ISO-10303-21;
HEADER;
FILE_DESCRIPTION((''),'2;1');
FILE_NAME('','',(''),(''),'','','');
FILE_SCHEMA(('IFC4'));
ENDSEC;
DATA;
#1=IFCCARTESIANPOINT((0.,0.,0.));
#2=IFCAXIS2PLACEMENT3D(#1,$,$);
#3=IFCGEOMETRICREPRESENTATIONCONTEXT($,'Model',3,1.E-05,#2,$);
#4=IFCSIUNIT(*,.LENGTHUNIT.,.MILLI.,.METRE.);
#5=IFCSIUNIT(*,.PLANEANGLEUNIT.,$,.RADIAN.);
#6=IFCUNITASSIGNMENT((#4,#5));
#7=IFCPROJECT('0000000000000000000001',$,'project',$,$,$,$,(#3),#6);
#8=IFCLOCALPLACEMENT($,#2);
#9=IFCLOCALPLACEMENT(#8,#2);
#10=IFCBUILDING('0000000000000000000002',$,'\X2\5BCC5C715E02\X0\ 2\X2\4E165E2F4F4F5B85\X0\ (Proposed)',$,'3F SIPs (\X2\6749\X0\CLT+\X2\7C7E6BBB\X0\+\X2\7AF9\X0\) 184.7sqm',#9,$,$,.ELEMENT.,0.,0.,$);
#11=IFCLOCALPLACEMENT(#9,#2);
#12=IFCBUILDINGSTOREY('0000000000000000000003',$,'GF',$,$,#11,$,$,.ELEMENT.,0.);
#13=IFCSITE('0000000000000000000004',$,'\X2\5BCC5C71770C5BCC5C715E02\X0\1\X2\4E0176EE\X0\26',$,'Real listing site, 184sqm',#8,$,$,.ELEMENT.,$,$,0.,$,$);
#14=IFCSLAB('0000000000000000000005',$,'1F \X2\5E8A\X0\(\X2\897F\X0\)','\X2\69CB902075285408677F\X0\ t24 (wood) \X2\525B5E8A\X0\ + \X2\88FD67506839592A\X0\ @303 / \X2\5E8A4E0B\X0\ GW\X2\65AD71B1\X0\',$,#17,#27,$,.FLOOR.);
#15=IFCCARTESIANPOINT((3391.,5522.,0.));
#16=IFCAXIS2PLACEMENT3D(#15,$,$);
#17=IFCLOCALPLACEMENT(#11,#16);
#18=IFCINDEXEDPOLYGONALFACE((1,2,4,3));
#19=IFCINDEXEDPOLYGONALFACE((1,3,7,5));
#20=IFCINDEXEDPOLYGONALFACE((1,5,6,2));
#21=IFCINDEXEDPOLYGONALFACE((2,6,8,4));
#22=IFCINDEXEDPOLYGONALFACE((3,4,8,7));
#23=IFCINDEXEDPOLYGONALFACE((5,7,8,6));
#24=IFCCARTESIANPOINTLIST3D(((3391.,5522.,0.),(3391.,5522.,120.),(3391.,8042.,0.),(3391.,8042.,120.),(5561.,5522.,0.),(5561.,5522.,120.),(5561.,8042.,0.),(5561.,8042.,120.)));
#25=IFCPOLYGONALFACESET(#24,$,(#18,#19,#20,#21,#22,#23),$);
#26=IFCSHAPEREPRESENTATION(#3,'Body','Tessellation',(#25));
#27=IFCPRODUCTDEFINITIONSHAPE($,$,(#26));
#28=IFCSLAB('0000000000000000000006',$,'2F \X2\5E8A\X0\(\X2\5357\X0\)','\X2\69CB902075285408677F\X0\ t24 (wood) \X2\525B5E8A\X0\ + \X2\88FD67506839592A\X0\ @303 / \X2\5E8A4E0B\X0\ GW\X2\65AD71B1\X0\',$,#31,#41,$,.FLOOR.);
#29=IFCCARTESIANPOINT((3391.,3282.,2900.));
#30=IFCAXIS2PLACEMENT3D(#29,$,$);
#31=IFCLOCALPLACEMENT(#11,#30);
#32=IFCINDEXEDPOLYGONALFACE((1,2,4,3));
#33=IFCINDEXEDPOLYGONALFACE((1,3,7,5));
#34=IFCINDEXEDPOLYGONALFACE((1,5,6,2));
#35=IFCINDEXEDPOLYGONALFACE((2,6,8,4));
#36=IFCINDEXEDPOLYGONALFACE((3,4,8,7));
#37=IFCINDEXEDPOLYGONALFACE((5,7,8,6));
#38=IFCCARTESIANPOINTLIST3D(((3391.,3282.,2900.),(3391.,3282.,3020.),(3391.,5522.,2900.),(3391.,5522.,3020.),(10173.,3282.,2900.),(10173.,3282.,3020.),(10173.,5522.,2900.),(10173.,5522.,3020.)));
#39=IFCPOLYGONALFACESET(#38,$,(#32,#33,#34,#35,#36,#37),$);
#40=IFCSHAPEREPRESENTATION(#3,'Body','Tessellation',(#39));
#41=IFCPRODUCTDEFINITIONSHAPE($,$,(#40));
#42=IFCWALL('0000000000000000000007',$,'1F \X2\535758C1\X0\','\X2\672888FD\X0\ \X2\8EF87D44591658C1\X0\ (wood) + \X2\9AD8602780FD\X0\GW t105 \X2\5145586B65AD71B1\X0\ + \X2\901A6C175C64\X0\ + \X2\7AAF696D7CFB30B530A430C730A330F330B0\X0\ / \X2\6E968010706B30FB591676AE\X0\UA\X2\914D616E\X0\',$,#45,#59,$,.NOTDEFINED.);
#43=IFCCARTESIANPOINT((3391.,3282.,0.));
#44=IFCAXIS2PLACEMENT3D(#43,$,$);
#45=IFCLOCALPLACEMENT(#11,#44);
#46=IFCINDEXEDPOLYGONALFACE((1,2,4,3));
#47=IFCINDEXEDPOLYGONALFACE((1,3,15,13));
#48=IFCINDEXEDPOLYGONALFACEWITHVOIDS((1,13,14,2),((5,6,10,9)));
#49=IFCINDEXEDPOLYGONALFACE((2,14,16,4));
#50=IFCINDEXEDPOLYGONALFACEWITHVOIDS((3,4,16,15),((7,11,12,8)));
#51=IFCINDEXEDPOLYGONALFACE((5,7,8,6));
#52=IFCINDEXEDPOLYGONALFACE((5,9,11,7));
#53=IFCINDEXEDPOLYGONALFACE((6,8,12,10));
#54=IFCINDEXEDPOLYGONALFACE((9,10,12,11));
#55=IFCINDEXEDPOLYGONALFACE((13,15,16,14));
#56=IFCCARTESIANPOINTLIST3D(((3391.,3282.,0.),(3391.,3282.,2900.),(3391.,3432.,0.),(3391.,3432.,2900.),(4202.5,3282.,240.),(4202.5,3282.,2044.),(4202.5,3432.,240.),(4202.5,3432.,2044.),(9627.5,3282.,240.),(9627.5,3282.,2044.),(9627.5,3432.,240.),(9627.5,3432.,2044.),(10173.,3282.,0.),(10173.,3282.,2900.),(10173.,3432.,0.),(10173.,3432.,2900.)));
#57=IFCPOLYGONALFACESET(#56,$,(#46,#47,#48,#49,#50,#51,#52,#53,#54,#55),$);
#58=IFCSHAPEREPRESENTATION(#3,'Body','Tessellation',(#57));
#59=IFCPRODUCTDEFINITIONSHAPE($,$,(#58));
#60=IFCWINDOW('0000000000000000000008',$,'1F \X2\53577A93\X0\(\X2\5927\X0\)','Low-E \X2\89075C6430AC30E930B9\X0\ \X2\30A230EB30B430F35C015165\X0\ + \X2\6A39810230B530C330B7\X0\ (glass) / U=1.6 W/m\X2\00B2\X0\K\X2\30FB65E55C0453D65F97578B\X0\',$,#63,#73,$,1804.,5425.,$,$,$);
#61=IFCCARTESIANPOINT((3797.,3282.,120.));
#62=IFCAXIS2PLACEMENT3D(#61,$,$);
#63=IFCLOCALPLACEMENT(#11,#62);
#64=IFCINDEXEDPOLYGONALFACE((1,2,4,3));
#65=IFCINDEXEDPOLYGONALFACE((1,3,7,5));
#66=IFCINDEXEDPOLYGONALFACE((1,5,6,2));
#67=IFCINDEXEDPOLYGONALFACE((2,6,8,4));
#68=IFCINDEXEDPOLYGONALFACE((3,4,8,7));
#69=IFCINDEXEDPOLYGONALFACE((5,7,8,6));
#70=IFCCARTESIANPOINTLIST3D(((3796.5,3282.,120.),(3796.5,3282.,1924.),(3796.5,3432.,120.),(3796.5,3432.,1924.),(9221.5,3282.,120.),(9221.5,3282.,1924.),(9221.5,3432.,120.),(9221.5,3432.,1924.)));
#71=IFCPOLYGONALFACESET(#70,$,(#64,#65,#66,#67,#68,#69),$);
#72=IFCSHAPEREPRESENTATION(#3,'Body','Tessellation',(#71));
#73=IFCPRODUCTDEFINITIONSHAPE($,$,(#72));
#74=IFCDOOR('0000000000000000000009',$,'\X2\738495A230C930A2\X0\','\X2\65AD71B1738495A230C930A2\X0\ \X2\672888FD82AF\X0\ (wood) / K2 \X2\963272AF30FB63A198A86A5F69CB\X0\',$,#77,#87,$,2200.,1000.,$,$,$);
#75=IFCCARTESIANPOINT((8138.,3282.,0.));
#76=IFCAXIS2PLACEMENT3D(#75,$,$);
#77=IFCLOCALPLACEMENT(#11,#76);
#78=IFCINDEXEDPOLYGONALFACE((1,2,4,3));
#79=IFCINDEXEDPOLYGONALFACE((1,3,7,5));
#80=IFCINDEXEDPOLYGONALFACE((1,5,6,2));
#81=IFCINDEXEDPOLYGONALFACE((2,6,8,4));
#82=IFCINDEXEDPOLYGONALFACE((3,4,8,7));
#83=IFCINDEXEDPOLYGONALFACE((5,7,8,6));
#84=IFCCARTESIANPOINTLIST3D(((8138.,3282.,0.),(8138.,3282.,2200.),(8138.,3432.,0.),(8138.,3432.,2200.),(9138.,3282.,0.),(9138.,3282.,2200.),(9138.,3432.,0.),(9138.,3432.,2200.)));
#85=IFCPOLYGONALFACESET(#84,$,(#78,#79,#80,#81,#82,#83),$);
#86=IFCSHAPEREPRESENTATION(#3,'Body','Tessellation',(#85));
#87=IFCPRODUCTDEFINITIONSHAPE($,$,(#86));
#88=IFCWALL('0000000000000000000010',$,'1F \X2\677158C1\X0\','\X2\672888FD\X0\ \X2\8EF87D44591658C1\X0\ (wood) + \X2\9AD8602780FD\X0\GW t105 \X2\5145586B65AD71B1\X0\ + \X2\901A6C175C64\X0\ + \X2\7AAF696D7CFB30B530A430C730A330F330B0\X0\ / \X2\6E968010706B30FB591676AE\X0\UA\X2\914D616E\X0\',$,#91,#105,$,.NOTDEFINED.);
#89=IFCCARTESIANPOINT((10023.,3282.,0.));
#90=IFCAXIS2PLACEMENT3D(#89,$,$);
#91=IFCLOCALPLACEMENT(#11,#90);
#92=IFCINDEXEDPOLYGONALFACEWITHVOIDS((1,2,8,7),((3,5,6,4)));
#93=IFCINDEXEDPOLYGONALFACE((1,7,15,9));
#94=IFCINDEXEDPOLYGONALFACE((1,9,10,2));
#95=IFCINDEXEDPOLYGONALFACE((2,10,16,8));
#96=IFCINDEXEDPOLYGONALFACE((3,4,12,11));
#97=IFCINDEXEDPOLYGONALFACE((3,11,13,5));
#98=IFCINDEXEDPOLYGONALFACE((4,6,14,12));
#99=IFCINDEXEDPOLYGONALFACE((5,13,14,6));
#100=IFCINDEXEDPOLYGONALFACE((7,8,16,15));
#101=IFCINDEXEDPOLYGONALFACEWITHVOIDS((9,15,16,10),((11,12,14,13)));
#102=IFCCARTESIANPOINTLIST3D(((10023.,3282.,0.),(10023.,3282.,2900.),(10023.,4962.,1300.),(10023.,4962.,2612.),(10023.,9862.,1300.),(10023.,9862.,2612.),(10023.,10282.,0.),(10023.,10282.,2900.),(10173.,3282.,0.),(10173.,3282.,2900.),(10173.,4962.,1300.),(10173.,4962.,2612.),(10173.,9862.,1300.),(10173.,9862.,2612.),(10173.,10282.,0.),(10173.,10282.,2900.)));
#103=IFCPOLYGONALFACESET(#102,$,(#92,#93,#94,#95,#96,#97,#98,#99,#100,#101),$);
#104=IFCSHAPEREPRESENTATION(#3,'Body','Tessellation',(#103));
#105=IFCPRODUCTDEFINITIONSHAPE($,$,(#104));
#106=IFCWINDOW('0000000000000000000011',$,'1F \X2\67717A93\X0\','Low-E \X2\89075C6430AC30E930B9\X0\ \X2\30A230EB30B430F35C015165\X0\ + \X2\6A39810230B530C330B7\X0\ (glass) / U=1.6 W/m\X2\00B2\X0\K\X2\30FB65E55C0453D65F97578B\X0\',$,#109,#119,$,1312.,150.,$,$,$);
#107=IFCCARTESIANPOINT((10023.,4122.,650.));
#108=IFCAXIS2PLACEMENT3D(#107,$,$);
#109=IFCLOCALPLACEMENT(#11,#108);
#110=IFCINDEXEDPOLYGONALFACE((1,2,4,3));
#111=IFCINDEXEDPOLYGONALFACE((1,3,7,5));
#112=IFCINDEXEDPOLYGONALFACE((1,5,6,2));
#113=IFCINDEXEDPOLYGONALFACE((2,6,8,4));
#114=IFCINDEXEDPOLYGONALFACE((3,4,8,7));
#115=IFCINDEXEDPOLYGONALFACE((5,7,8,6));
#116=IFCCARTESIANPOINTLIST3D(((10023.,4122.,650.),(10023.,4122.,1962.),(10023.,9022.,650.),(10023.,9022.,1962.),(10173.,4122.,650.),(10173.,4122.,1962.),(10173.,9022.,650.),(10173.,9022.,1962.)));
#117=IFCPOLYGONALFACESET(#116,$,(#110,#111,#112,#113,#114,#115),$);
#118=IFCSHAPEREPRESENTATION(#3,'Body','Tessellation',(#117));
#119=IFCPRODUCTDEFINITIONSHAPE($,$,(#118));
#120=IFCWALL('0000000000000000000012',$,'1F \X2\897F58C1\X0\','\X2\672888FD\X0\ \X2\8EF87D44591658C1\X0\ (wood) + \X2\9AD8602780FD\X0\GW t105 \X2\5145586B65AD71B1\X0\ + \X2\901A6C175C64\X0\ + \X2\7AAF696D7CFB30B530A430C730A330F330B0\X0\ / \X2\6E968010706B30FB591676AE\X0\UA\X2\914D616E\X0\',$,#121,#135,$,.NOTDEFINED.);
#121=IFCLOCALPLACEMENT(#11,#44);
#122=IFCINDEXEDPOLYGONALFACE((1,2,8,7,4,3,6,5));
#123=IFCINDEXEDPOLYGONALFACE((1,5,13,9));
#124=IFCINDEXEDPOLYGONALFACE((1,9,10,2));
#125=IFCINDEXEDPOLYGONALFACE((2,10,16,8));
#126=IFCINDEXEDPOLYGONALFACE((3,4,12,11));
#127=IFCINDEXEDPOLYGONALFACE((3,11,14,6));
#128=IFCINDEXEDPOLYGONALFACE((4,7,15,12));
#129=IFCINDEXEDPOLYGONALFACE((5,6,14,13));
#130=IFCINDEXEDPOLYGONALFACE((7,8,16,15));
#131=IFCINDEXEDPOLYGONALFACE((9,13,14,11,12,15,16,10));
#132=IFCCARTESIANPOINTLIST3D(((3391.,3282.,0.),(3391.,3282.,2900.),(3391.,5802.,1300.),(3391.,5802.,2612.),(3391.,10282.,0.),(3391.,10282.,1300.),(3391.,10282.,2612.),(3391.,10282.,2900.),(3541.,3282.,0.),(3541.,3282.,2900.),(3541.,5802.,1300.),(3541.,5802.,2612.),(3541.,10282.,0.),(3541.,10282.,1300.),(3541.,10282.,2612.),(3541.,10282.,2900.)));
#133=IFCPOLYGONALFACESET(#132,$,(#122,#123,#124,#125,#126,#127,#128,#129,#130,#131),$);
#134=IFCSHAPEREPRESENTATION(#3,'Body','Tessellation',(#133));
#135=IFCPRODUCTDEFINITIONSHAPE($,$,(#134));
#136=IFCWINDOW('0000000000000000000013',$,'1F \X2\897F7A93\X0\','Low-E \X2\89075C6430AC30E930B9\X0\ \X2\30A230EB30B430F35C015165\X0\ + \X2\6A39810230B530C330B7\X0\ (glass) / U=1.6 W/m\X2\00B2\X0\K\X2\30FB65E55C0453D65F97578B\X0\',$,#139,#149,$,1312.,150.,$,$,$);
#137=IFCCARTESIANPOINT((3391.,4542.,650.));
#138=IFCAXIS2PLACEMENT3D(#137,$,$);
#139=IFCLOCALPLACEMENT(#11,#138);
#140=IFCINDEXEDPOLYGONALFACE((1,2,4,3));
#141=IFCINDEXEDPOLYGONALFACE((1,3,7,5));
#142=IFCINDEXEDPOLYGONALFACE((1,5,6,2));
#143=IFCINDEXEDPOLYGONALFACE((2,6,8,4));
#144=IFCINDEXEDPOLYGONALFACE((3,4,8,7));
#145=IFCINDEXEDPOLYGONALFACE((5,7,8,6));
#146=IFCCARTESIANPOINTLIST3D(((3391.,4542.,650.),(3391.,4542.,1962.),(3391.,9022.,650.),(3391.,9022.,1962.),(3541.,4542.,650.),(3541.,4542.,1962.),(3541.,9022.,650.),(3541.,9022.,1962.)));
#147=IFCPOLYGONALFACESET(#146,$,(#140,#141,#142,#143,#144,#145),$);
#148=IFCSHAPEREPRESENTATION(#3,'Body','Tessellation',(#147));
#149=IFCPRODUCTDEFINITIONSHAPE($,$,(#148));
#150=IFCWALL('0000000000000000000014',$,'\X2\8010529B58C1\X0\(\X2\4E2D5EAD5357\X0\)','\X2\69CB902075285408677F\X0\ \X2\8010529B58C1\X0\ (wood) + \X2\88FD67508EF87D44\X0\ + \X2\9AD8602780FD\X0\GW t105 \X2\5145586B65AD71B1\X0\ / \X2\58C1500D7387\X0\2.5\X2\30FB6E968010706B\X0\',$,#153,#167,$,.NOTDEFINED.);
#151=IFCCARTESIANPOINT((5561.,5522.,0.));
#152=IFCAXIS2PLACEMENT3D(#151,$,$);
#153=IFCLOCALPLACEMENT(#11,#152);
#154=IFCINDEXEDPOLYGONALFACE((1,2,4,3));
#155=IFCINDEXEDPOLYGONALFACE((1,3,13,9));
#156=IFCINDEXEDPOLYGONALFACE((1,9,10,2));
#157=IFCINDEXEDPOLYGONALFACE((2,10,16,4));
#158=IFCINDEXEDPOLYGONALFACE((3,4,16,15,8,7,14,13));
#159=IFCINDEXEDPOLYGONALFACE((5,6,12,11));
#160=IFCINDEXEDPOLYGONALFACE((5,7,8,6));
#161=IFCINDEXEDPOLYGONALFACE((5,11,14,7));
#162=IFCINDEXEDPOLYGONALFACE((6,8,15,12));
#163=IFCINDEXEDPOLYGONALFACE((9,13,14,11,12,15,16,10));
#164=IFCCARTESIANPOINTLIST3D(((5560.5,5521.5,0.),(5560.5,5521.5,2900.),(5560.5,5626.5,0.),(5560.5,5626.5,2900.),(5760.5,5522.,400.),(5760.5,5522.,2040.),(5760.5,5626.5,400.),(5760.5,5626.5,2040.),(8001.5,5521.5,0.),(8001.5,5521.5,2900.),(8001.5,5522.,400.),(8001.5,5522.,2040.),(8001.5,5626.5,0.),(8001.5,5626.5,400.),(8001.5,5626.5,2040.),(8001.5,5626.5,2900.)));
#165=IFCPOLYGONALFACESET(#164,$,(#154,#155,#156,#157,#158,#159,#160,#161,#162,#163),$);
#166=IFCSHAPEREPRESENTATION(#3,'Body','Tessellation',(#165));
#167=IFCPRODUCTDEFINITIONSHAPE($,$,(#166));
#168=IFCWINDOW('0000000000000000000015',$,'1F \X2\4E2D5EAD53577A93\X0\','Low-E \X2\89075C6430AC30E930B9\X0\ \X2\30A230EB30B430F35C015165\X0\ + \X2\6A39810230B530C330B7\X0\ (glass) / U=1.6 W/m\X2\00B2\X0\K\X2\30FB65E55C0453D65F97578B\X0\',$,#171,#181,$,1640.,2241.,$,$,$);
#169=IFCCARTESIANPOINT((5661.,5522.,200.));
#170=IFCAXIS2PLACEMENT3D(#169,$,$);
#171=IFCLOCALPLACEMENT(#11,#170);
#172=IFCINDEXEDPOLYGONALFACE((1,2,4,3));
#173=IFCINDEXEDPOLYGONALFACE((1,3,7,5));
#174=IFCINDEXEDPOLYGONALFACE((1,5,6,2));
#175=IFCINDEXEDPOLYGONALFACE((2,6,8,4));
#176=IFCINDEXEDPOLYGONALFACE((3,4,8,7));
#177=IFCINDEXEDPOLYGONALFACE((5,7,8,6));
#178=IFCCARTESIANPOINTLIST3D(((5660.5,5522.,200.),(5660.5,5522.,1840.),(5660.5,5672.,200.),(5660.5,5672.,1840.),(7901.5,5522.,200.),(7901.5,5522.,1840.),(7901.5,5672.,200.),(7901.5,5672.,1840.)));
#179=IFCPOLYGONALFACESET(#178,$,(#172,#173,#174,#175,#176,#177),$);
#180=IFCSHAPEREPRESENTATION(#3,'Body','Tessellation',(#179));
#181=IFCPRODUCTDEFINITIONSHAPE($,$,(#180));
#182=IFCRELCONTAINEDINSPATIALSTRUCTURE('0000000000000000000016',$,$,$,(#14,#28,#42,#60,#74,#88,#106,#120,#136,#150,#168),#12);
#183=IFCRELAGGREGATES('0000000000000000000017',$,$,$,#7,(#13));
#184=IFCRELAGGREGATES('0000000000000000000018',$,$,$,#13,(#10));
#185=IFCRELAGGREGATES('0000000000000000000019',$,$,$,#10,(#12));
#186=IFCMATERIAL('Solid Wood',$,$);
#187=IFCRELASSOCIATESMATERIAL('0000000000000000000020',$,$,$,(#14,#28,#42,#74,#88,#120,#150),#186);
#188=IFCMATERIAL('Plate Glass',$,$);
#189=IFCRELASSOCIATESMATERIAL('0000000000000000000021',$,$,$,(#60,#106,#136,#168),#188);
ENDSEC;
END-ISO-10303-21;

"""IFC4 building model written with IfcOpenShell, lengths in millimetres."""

from ifc_helpers import new_model, si_unit, frame, frame_2d, origin, place, context, project, spatial, rectangle, extrude, material, element, fill, save


model = new_model("IFC4")

# Units and contexts
model_context = context("Model", 3, precision=1e-05, world=origin())
ifc_project = project(units=[si_unit("LENGTHUNIT", "METRE", prefix="MILLI"), si_unit("PLANEANGLEUNIT", "RADIAN")], contexts=[model_context])

# Site, building, storey
site_placement = place(None, origin())
site = spatial("IfcSite", under=ifc_project, at=site_placement, Name="富山県富山市1丁目26", ObjectType="Real listing site, 184sqm", CompositionType="ELEMENT", RefElevation=0.0)
building_placement = place(site_placement, origin())
building = spatial("IfcBuilding", under=site, at=building_placement, Name="富山市 2世帯住宅 (Proposed)", ObjectType="3F SIPs (杉CLT+籾殻+竹) 184.7sqm", CompositionType="ELEMENT", ElevationOfRefHeight=0.0, ElevationOfTerrain=0.0)
storey_placement = place(building_placement, origin())
storey = spatial("IfcBuildingStorey", under=building, at=storey_placement, Name="GF", CompositionType="ELEMENT", Elevation=0.0)

# Slabs
ifc_material_1 = material(Name="Solid Wood")
slab_1_placement = place(storey_placement, frame((3391.0, 5522.0, 0.0)))
element("IfcSlab", 1, at=slab_1_placement, inside=storey, material=ifc_material_1, Name="1F 床(西)", Description="構造用合板 t24 (wood) 剛床 + 製材根太 @303 / 床下 GW断熱", PredefinedType="FLOOR", context=model_context, shape_type="SweptSolid", body=[
    extrude(rectangle(XDim=2170.0, YDim=2520.0, at=frame_2d((1085.0, 1260.0))), frame((3391.0, 5522.0, 0.0)), (0.0, 0.0, 1.0), 120.0),
])
slab_2_placement = place(storey_placement, frame((3391.0, 3282.0, 2900.0)))
element("IfcSlab", 2, at=slab_2_placement, inside=storey, material=ifc_material_1, Name="2F 床(南)", Description="構造用合板 t24 (wood) 剛床 + 製材根太 @303 / 床下 GW断熱", PredefinedType="FLOOR", context=model_context, shape_type="SweptSolid", body=[
    extrude(rectangle(XDim=6782.0, YDim=2240.0, at=frame_2d((3391.0, 1120.0))), frame((3391.0, 3282.0, 2900.0)), (0.0, 0.0, 1.0), 120.0),
])

# Wall, openings, window, door
wall_1_placement = place(storey_placement, frame((3391.0, 3282.0, 0.0)))
wall_1 = element("IfcWall", 3, at=wall_1_placement, inside=storey, material=ifc_material_1, Name="1F 南壁", Description="木製 軸組外壁 (wood) + 高性能GW t105 充填断熱 + 通気層 + 窯業系サイディング / 準耐火・外皮UA配慮", PredefinedType="NOTDEFINED", context=model_context, shape_type="SweptSolid", body=[
    extrude(rectangle(XDim=6782.0, YDim=150.0, at=frame_2d((3391.0, 75.0))), frame((3391.0, 3282.0, 0.0)), (0.0, 0.0, 1.0), 2900.0),
])
opening_1_placement = place(storey_placement, frame((3797.0, 3282.0, 120.0)))
opening_1 = element("IfcOpeningElement", 4, at=opening_1_placement, cuts=wall_1, PredefinedType="NOTDEFINED", context=model_context, shape_type="SweptSolid", body=[
    extrude(rectangle(XDim=5425.0, YDim=150.0, at=frame_2d((2712.0, 75.0))), frame((3797.0, 3282.0, 120.0)), (0.0, 0.0, 1.0), 1804.0),
])
opening_2_placement = place(storey_placement, frame((8138.0, 3282.0, 0.0)))
opening_2 = element("IfcOpeningElement", 5, at=opening_2_placement, cuts=wall_1, PredefinedType="NOTDEFINED", context=model_context, shape_type="SweptSolid", body=[
    extrude(rectangle(XDim=1000.0, YDim=150.0, at=frame_2d((500.0, 75.0))), frame((8138.0, 3282.0, 0.0)), (0.0, 0.0, 1.0), 2200.0),
])
ifc_material_2 = material(Name="Plate Glass")
window_1_placement = place(storey_placement, frame((3797.0, 3282.0, 120.0)))
window_1 = element("IfcWindow", 6, at=window_1_placement, inside=storey, material=ifc_material_2, Name="1F 南窓(大)", Description="Low-E 複層ガラス アルゴン封入 + 樹脂サッシ (glass) / U=1.6 W/m²K・日射取得型", OverallHeight=1804.0, OverallWidth=5425.0, context=model_context, shape_type="SweptSolid", body=[
    extrude(rectangle(XDim=5425.0, YDim=150.0, at=frame_2d((2712.0, 75.0))), frame((3797.0, 3282.0, 120.0)), (0.0, 0.0, 1.0), 1804.0),
])
fill(opening_1, window_1)
door_placement = place(storey_placement, frame((8138.0, 3282.0, 0.0)))
door = element("IfcDoor", 7, at=door_placement, inside=storey, material=ifc_material_1, Name="玄関ドア", Description="断熱玄関ドア 木製芯 (wood) / K2 防犯・採風機構", OverallHeight=2200.0, OverallWidth=1000.0, context=model_context, shape_type="SweptSolid", body=[
    extrude(rectangle(XDim=1000.0, YDim=150.0, at=frame_2d((500.0, 75.0))), frame((8138.0, 3282.0, 0.0)), (0.0, 0.0, 1.0), 2200.0),
])
fill(opening_2, door)

# Walls, openings, windows
wall_2_placement = place(storey_placement, frame((10023.0, 3282.0, 0.0)))
wall_2 = element("IfcWall", 8, at=wall_2_placement, inside=storey, material=ifc_material_1, Name="1F 東壁", Description="木製 軸組外壁 (wood) + 高性能GW t105 充填断熱 + 通気層 + 窯業系サイディング / 準耐火・外皮UA配慮", PredefinedType="NOTDEFINED", context=model_context, shape_type="SweptSolid", body=[
    extrude(rectangle(XDim=150.0, YDim=7000.0, at=frame_2d((75.0, 3500.0))), frame((10023.0, 3282.0, 0.0)), (0.0, 0.0, 1.0), 2900.0),
])
opening_3_placement = place(storey_placement, frame((10023.0, 4122.0, 650.0)))
opening_3 = element("IfcOpeningElement", 9, at=opening_3_placement, cuts=wall_2, PredefinedType="NOTDEFINED", context=model_context, shape_type="SweptSolid", body=[
    extrude(rectangle(XDim=150.0, YDim=4900.0, at=frame_2d((75.0, 2450.0))), frame((10023.0, 4122.0, 650.0)), (0.0, 0.0, 1.0), 1312.0),
])
window_2_placement = place(storey_placement, frame((10023.0, 4122.0, 650.0)))
window_2 = element("IfcWindow", 10, at=window_2_placement, inside=storey, material=ifc_material_2, Name="1F 東窓", Description="Low-E 複層ガラス アルゴン封入 + 樹脂サッシ (glass) / U=1.6 W/m²K・日射取得型", OverallHeight=1312.0, OverallWidth=150.0, context=model_context, shape_type="SweptSolid", body=[
    extrude(rectangle(XDim=150.0, YDim=4900.0, at=frame_2d((75.0, 2450.0))), frame((10023.0, 4122.0, 650.0)), (0.0, 0.0, 1.0), 1312.0),
])
fill(opening_3, window_2)
wall_3_placement = place(storey_placement, frame((3391.0, 3282.0, 0.0)))
wall_3 = element("IfcWall", 11, at=wall_3_placement, inside=storey, material=ifc_material_1, Name="1F 西壁", Description="木製 軸組外壁 (wood) + 高性能GW t105 充填断熱 + 通気層 + 窯業系サイディング / 準耐火・外皮UA配慮", PredefinedType="NOTDEFINED", context=model_context, shape_type="SweptSolid", body=[
    extrude(rectangle(XDim=150.0, YDim=7000.0, at=frame_2d((75.0, 3500.0))), frame((3391.0, 3282.0, 0.0)), (0.0, 0.0, 1.0), 2900.0),
])
opening_4_placement = place(storey_placement, frame((3391.0, 4542.0, 650.0)))
opening_4 = element("IfcOpeningElement", 12, at=opening_4_placement, cuts=wall_3, PredefinedType="NOTDEFINED", context=model_context, shape_type="SweptSolid", body=[
    extrude(rectangle(XDim=150.0, YDim=4480.0, at=frame_2d((75.0, 2240.0))), frame((3391.0, 4542.0, 650.0)), (0.0, 0.0, 1.0), 1312.0),
])
window_3_placement = place(storey_placement, frame((3391.0, 4542.0, 650.0)))
window_3 = element("IfcWindow", 13, at=window_3_placement, inside=storey, material=ifc_material_2, Name="1F 西窓", Description="Low-E 複層ガラス アルゴン封入 + 樹脂サッシ (glass) / U=1.6 W/m²K・日射取得型", OverallHeight=1312.0, OverallWidth=150.0, context=model_context, shape_type="SweptSolid", body=[
    extrude(rectangle(XDim=150.0, YDim=4480.0, at=frame_2d((75.0, 2240.0))), frame((3391.0, 4542.0, 650.0)), (0.0, 0.0, 1.0), 1312.0),
])
fill(opening_4, window_3)
wall_4_placement = place(storey_placement, frame((5561.0, 5522.0, 0.0)))
wall_4 = element("IfcWall", 14, at=wall_4_placement, inside=storey, material=ifc_material_1, Name="耐力壁(中庭南)", Description="構造用合板 耐力壁 (wood) + 製材軸組 + 高性能GW t105 充填断熱 / 壁倍率2.5・準耐火", PredefinedType="NOTDEFINED", context=model_context, shape_type="SweptSolid", body=[
    extrude(rectangle(XDim=2441.0, YDim=105.0, at=frame_2d((1220.0, 52.0))), frame((5561.0, 5522.0, 0.0)), (0.0, 0.0, 1.0), 2900.0),
])
opening_5_placement = place(storey_placement, frame((5661.0, 5522.0, 200.0)))
opening_5 = element("IfcOpeningElement", 15, at=opening_5_placement, cuts=wall_4, PredefinedType="NOTDEFINED", context=model_context, shape_type="SweptSolid", body=[
    extrude(rectangle(XDim=2241.0, YDim=150.0, at=frame_2d((1120.0, 75.0))), frame((5661.0, 5522.0, 200.0)), (0.0, 0.0, 1.0), 1640.0),
])
window_4_placement = place(storey_placement, frame((5661.0, 5522.0, 200.0)))
window_4 = element("IfcWindow", 16, at=window_4_placement, inside=storey, material=ifc_material_2, Name="1F 中庭南窓", Description="Low-E 複層ガラス アルゴン封入 + 樹脂サッシ (glass) / U=1.6 W/m²K・日射取得型", OverallHeight=1640.0, OverallWidth=2241.0, context=model_context, shape_type="SweptSolid", body=[
    extrude(rectangle(XDim=2241.0, YDim=150.0, at=frame_2d((1120.0, 75.0))), frame((5661.0, 5522.0, 200.0)), (0.0, 0.0, 1.0), 1640.0),
])
fill(opening_5, window_4)

save(model, "model.ifc")
